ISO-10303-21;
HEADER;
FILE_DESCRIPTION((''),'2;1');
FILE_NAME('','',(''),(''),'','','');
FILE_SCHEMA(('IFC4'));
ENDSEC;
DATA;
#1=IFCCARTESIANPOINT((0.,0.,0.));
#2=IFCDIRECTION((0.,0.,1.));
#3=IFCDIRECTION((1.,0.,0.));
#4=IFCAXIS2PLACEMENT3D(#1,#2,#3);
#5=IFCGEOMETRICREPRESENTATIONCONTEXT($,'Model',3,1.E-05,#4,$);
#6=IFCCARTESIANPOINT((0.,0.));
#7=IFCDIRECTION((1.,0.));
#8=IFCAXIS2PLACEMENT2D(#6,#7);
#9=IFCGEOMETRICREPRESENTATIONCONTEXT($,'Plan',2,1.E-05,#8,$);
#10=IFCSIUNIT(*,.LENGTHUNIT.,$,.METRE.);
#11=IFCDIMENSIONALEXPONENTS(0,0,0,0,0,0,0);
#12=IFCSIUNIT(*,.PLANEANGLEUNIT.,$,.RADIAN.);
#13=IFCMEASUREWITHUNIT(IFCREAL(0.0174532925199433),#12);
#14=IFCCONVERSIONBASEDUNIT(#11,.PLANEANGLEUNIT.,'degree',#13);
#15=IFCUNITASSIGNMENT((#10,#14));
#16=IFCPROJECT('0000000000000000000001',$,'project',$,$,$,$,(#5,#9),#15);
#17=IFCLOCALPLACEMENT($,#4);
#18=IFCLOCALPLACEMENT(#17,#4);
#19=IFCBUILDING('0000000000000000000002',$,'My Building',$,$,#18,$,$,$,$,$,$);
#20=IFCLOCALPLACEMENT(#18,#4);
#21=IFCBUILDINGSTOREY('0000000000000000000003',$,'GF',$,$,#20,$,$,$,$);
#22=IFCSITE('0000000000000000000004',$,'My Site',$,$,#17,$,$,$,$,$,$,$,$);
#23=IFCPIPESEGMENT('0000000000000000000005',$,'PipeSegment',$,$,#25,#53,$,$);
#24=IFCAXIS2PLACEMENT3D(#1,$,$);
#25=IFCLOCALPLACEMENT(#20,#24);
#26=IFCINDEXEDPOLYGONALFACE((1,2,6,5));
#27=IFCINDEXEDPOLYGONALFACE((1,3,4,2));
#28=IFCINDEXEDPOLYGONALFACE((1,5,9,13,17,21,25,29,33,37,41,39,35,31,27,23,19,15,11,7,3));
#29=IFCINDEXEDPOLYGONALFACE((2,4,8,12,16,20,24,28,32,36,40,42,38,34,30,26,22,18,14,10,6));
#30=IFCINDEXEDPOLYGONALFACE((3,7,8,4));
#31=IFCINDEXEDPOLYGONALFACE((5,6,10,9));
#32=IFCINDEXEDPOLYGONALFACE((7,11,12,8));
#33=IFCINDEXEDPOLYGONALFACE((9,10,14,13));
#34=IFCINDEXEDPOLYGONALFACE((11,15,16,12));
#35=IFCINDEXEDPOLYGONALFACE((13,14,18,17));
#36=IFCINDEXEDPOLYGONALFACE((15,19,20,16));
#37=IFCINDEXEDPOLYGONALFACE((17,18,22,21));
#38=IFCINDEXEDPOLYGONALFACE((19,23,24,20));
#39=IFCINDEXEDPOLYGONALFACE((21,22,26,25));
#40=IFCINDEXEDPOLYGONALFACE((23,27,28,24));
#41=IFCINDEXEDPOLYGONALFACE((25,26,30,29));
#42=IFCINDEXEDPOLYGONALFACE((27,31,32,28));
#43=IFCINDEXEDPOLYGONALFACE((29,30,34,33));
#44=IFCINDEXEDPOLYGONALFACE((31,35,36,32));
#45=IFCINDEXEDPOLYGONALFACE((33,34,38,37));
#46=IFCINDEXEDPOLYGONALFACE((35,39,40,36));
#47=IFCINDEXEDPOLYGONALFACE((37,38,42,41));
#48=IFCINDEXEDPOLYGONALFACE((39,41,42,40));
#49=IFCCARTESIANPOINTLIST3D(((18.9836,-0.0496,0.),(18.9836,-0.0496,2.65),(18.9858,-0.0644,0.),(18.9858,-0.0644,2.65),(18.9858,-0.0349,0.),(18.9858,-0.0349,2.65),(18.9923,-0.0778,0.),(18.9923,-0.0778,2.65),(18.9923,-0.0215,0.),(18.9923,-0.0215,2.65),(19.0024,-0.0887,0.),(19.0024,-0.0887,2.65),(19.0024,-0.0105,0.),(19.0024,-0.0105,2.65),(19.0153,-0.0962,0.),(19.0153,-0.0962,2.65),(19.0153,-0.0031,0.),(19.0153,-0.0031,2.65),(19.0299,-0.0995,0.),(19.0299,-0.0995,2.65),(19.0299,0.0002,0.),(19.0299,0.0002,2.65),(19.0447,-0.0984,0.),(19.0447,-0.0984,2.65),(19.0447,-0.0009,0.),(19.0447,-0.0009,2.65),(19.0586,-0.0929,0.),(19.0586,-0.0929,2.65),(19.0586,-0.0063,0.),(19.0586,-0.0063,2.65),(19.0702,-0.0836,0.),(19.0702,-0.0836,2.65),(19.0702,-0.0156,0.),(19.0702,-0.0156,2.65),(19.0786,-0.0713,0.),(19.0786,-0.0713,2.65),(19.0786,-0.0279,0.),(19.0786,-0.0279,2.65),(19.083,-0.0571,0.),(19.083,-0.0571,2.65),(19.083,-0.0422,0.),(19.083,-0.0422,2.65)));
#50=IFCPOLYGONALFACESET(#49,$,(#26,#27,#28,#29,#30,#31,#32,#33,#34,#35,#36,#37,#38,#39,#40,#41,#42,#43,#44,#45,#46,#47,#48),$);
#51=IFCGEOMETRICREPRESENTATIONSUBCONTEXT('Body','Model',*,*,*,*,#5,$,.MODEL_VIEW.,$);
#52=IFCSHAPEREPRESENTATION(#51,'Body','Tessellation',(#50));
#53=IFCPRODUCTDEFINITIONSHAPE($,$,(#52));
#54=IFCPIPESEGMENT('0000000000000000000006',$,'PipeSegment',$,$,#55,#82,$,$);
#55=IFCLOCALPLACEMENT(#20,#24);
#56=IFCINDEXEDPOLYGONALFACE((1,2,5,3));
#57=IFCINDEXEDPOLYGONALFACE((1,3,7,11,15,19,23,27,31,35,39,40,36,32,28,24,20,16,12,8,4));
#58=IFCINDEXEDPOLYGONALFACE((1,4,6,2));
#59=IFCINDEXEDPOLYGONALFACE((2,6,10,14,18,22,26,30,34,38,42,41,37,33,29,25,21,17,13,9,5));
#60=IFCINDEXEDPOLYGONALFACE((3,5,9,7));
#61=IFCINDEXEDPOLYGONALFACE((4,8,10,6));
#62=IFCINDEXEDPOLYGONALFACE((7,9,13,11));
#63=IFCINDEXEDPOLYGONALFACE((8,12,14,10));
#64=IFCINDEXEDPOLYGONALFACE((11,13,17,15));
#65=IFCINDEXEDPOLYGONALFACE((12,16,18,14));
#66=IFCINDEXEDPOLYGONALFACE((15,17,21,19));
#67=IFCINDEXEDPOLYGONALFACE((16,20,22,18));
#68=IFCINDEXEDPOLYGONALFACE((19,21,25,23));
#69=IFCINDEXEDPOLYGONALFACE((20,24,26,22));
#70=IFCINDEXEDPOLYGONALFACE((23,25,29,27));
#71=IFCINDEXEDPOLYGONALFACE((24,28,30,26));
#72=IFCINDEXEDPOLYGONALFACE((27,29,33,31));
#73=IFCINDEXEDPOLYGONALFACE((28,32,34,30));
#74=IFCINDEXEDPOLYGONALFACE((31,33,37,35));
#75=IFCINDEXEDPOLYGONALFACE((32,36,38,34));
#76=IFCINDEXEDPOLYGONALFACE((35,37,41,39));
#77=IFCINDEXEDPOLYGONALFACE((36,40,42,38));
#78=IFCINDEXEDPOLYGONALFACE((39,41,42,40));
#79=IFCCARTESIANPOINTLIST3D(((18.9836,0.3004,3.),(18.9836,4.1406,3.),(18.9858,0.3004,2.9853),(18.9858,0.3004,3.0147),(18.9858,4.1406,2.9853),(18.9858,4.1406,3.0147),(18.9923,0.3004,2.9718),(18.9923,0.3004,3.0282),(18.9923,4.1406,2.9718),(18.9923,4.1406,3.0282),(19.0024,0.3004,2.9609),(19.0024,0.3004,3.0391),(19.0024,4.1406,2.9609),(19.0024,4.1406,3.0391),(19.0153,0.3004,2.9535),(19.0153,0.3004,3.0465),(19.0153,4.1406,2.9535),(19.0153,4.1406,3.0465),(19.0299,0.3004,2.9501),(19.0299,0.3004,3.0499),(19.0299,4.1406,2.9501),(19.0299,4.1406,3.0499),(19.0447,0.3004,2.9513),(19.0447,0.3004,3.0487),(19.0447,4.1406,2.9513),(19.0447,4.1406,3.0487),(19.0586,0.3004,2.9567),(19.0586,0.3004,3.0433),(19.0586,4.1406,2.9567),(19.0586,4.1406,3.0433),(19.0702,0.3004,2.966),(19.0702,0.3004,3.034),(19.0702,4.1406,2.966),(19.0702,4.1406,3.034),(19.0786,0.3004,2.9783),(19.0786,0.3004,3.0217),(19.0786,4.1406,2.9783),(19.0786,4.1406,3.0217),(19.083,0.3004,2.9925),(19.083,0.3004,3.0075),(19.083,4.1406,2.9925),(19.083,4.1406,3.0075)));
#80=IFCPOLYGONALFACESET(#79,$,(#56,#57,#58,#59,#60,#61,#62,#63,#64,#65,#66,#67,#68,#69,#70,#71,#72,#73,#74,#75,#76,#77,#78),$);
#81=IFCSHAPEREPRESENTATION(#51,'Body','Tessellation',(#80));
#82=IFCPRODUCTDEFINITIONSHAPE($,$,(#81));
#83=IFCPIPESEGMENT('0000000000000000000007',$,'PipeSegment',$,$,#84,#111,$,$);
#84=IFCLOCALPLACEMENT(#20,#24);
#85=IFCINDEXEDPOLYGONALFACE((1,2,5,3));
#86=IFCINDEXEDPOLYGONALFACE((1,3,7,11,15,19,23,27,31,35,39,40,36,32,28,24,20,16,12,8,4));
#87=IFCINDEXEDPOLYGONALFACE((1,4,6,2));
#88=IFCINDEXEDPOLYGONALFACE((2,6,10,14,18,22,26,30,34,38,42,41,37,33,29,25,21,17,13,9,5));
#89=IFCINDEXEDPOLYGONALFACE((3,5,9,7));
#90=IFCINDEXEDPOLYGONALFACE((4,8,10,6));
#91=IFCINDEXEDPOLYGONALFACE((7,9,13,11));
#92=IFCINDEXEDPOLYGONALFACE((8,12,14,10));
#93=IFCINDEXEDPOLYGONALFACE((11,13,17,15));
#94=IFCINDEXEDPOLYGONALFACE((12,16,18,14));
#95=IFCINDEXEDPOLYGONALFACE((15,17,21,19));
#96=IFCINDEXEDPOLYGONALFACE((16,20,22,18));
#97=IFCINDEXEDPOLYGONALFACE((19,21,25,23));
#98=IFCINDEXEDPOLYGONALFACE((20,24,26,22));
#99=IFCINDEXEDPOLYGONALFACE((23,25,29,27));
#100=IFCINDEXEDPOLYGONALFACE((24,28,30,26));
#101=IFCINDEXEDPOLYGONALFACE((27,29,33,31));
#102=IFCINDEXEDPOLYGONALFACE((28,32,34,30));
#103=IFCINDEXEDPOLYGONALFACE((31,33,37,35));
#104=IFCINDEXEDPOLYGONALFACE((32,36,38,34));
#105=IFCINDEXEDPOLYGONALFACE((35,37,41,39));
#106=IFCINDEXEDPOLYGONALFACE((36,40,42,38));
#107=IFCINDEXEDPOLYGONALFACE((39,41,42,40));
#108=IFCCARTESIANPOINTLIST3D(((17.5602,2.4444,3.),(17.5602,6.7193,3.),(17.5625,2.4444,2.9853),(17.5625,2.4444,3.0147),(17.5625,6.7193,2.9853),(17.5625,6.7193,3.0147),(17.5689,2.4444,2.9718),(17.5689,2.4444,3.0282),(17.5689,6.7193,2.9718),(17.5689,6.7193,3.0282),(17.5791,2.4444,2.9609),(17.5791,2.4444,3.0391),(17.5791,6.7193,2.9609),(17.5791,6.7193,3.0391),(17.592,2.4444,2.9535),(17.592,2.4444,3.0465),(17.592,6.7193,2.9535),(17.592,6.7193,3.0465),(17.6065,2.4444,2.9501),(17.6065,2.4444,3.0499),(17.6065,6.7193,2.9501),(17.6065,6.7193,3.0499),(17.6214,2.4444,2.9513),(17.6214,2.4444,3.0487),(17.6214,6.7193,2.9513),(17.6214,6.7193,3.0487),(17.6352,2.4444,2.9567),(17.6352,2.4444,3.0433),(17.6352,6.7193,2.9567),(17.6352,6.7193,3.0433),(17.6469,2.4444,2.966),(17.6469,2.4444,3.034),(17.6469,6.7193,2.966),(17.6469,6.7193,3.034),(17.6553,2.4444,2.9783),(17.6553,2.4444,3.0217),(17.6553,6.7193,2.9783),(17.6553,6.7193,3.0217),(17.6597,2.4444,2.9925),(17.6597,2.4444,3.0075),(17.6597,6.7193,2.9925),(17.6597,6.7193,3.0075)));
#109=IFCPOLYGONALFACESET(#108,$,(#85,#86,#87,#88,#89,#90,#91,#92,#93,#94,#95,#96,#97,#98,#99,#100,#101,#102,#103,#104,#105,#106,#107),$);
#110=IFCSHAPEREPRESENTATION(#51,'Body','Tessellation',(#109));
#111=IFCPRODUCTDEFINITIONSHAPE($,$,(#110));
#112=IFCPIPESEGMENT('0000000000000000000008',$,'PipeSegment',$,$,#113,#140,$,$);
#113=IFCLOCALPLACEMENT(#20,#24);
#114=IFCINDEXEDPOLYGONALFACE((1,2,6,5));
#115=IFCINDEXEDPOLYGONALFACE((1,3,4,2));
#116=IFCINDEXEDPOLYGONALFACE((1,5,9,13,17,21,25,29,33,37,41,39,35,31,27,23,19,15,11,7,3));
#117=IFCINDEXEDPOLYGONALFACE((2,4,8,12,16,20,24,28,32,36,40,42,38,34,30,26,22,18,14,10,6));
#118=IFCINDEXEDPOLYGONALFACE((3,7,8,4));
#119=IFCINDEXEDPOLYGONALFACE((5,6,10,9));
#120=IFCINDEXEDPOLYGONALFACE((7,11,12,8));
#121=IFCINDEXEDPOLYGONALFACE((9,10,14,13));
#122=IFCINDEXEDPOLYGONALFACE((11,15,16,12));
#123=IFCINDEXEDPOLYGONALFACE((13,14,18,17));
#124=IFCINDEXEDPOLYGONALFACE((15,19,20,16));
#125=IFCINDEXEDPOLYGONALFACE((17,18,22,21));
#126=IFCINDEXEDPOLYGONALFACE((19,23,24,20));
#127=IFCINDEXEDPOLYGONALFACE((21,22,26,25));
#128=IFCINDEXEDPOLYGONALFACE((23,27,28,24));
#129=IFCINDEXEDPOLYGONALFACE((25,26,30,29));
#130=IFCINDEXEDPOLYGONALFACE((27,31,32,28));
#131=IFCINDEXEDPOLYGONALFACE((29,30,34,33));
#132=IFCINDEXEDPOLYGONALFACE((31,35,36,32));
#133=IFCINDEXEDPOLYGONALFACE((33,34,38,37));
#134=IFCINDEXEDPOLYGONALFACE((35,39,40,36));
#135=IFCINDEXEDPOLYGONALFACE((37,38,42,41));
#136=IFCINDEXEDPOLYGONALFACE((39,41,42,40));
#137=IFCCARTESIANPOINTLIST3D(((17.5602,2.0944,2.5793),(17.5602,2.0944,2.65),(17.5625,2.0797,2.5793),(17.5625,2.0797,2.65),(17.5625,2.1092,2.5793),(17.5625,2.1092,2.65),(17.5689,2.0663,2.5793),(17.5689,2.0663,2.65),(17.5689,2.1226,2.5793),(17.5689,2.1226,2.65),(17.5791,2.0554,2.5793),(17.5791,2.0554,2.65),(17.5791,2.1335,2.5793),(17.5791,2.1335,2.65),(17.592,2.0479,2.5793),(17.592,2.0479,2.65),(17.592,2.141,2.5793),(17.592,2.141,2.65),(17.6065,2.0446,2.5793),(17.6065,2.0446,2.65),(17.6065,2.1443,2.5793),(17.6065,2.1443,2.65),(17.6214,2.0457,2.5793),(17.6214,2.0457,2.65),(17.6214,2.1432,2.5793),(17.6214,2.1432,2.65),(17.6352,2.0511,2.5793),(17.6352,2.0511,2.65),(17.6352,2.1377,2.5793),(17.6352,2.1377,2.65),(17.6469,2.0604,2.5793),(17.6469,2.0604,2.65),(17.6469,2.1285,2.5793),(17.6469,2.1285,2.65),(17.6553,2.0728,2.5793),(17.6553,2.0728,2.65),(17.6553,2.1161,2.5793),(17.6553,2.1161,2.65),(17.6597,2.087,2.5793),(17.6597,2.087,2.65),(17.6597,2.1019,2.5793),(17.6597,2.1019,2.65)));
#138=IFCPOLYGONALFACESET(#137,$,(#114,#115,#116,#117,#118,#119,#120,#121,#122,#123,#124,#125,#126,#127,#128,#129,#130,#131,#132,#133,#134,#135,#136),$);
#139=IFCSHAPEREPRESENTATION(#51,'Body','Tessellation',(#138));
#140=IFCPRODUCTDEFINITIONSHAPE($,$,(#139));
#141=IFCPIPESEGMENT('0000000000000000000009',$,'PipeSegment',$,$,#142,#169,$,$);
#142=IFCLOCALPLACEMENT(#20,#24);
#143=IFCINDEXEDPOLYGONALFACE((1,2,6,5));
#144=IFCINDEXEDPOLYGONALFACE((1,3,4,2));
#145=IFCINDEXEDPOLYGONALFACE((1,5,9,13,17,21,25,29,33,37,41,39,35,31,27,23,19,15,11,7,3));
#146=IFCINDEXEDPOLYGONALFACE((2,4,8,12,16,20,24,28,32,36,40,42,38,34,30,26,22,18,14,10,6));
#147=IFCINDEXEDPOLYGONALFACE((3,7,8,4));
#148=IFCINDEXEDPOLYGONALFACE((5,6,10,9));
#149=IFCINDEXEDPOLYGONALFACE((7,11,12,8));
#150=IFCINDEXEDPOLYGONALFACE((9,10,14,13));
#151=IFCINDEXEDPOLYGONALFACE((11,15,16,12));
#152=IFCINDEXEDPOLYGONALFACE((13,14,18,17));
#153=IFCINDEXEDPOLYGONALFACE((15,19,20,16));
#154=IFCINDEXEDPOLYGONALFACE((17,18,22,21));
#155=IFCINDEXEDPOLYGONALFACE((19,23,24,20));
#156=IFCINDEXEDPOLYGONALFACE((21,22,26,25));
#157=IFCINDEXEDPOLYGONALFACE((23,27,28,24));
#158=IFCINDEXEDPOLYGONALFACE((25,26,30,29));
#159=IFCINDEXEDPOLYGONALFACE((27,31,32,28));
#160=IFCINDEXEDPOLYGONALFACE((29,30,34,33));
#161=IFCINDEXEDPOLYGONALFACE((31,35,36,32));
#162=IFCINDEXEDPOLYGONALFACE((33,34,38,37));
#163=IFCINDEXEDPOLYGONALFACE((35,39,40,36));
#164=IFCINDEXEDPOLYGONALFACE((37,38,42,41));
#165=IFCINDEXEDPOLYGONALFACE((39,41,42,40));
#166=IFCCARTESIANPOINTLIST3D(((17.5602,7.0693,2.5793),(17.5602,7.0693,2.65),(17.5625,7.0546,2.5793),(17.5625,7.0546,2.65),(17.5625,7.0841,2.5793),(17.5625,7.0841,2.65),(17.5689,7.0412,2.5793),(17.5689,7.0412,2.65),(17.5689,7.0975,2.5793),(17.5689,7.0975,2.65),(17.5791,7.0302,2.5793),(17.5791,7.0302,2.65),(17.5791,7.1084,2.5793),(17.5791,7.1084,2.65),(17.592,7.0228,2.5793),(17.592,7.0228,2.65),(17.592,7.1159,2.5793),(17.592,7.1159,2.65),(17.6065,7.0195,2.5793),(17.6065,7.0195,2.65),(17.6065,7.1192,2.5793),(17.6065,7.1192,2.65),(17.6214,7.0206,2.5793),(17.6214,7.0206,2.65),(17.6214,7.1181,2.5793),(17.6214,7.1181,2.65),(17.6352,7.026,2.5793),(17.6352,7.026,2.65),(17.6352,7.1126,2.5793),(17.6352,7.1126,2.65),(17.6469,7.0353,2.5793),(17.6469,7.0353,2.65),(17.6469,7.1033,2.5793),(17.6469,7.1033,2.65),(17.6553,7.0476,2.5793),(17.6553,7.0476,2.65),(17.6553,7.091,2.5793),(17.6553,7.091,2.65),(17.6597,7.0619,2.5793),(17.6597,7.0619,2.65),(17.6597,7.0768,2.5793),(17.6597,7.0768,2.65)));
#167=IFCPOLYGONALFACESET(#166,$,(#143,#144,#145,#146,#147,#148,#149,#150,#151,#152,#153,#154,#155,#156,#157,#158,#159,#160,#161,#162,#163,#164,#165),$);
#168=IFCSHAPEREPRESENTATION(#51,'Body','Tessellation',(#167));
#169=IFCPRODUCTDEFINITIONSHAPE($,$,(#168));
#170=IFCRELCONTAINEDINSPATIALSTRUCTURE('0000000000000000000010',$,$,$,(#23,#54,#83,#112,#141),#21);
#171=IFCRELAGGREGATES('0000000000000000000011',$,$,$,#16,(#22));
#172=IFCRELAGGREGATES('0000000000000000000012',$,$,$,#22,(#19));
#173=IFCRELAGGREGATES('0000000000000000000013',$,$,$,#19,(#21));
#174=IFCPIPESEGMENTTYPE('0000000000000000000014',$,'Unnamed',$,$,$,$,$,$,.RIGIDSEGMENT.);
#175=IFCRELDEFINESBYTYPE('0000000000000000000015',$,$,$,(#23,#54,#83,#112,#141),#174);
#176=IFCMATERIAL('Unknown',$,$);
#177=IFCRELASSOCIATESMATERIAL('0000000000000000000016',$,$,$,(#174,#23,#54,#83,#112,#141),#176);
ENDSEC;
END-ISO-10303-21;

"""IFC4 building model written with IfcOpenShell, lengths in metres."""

from ifc_helpers import new_model, entity, si_unit, converted_unit, frame, origin_with_axes, origin_2d_with_axis, place, context, subcontext, project, spatial, circle, extrude, material, material_profile, profile_set, profile_usage, type_object, element, save


model = new_model("IFC4")

# Units and contexts
model_context = context("Model", 3, precision=1e-05, world=origin_with_axes())
plan_context = context("Plan", 2, precision=1e-05, world=origin_2d_with_axis())
body_context_1 = subcontext(model_context, "Body", "Model", "MODEL_VIEW")
ifc_project = project(units=[si_unit("LENGTHUNIT", "METRE"), converted_unit("PLANEANGLEUNIT", "degree", entity("IfcReal", 0.0174532925199433), si_unit("PLANEANGLEUNIT", "RADIAN"), dimensions=[0, 0, 0, 0, 0, 0, 0])], contexts=[model_context, plan_context])

# Site, building, storey
site_placement = place(None, origin_with_axes())
site = spatial("IfcSite", under=ifc_project, at=site_placement, Name="My Site")
building_placement = place(site_placement, origin_with_axes())
building = spatial("IfcBuilding", under=site, at=building_placement, Name="My Building")
storey_placement = place(building_placement, origin_with_axes())
storey = spatial("IfcBuildingStorey", under=building, at=storey_placement, Name="GF")

# Shared definitions
ifc_material = material(Name="Unknown")

# Pipe segments
ifc_material_profile = material_profile(ifc_material, circle(Radius=0.05))
ifc_profile_set = profile_set([ifc_material_profile])
ifc_profile_usage_1 = profile_usage(ifc_profile_set, cardinal=5)
pipe_segment_type = type_object("IfcPipeSegmentType", Name="Unnamed", PredefinedType="RIGIDSEGMENT", material=ifc_profile_set)
pipe_segment_1_placement = place(storey_placement, frame((19.0336, -0.0496, 0.0), z_axis=(0.0, 0.0, 1.0), x_axis=(-1.0, 0.0, 0.0)))
element("IfcPipeSegment", 1, at=pipe_segment_1_placement, inside=storey, type_object=pipe_segment_type, material=ifc_profile_usage_1, Name="PipeSegment", context=body_context_1, shape_type="SweptSolid", body=[
    extrude(circle(Radius=0.05), origin_with_axes(), (0.0, 0.0, 1.0), 2.65),
])
ifc_profile_usage_2 = profile_usage(ifc_profile_set, cardinal=5)
pipe_segment_2_placement = place(storey_placement, frame((19.0336, 0.3004, 3.0), z_axis=(0.0, 1.0, 0.0), x_axis=(-1.0, 0.0, 0.0)))
element("IfcPipeSegment", 2, at=pipe_segment_2_placement, inside=storey, type_object=pipe_segment_type, material=ifc_profile_usage_2, Name="PipeSegment", context=body_context_1, shape_type="SweptSolid", body=[
    extrude(circle(Radius=0.05), origin_with_axes(), (0.0, 0.0, 1.0), 3.8402),
])
ifc_profile_usage_3 = profile_usage(ifc_profile_set, cardinal=5)
pipe_segment_3_placement = place(storey_placement, frame((17.6102, 2.4444, 3.0), z_axis=(0.0, 1.0, 0.0), x_axis=(-1.0, 0.0, 0.0)))
element("IfcPipeSegment", 3, at=pipe_segment_3_placement, inside=storey, type_object=pipe_segment_type, material=ifc_profile_usage_3, Name="PipeSegment", context=body_context_1, shape_type="SweptSolid", body=[
    extrude(circle(Radius=0.05), origin_with_axes(), (0.0, 0.0, 1.0), 4.2749),
])
ifc_profile_usage_4 = profile_usage(ifc_profile_set, cardinal=5)
pipe_segment_4_placement = place(storey_placement, frame((17.6102, 2.0944, 2.65), z_axis=(0.0, 0.0, -1.0), x_axis=(-1.0, 0.0, 0.0)))
element("IfcPipeSegment", 4, at=pipe_segment_4_placement, inside=storey, type_object=pipe_segment_type, material=ifc_profile_usage_4, Name="PipeSegment", context=body_context_1, shape_type="SweptSolid", body=[
    extrude(circle(Radius=0.05), origin_with_axes(), (0.0, 0.0, 1.0), 0.0707),
])
ifc_profile_usage_5 = profile_usage(ifc_profile_set, cardinal=5)
pipe_segment_5_placement = place(storey_placement, frame((17.6102, 7.0693, 2.65), z_axis=(0.0, 0.0, -1.0), x_axis=(-1.0, 0.0, 0.0)))
element("IfcPipeSegment", 5, at=pipe_segment_5_placement, inside=storey, type_object=pipe_segment_type, material=ifc_profile_usage_5, Name="PipeSegment", context=body_context_1, shape_type="SweptSolid", body=[
    extrude(circle(Radius=0.05), origin_with_axes(), (0.0, 0.0, 1.0), 0.0707),
])

save(model, "model.ifc")
